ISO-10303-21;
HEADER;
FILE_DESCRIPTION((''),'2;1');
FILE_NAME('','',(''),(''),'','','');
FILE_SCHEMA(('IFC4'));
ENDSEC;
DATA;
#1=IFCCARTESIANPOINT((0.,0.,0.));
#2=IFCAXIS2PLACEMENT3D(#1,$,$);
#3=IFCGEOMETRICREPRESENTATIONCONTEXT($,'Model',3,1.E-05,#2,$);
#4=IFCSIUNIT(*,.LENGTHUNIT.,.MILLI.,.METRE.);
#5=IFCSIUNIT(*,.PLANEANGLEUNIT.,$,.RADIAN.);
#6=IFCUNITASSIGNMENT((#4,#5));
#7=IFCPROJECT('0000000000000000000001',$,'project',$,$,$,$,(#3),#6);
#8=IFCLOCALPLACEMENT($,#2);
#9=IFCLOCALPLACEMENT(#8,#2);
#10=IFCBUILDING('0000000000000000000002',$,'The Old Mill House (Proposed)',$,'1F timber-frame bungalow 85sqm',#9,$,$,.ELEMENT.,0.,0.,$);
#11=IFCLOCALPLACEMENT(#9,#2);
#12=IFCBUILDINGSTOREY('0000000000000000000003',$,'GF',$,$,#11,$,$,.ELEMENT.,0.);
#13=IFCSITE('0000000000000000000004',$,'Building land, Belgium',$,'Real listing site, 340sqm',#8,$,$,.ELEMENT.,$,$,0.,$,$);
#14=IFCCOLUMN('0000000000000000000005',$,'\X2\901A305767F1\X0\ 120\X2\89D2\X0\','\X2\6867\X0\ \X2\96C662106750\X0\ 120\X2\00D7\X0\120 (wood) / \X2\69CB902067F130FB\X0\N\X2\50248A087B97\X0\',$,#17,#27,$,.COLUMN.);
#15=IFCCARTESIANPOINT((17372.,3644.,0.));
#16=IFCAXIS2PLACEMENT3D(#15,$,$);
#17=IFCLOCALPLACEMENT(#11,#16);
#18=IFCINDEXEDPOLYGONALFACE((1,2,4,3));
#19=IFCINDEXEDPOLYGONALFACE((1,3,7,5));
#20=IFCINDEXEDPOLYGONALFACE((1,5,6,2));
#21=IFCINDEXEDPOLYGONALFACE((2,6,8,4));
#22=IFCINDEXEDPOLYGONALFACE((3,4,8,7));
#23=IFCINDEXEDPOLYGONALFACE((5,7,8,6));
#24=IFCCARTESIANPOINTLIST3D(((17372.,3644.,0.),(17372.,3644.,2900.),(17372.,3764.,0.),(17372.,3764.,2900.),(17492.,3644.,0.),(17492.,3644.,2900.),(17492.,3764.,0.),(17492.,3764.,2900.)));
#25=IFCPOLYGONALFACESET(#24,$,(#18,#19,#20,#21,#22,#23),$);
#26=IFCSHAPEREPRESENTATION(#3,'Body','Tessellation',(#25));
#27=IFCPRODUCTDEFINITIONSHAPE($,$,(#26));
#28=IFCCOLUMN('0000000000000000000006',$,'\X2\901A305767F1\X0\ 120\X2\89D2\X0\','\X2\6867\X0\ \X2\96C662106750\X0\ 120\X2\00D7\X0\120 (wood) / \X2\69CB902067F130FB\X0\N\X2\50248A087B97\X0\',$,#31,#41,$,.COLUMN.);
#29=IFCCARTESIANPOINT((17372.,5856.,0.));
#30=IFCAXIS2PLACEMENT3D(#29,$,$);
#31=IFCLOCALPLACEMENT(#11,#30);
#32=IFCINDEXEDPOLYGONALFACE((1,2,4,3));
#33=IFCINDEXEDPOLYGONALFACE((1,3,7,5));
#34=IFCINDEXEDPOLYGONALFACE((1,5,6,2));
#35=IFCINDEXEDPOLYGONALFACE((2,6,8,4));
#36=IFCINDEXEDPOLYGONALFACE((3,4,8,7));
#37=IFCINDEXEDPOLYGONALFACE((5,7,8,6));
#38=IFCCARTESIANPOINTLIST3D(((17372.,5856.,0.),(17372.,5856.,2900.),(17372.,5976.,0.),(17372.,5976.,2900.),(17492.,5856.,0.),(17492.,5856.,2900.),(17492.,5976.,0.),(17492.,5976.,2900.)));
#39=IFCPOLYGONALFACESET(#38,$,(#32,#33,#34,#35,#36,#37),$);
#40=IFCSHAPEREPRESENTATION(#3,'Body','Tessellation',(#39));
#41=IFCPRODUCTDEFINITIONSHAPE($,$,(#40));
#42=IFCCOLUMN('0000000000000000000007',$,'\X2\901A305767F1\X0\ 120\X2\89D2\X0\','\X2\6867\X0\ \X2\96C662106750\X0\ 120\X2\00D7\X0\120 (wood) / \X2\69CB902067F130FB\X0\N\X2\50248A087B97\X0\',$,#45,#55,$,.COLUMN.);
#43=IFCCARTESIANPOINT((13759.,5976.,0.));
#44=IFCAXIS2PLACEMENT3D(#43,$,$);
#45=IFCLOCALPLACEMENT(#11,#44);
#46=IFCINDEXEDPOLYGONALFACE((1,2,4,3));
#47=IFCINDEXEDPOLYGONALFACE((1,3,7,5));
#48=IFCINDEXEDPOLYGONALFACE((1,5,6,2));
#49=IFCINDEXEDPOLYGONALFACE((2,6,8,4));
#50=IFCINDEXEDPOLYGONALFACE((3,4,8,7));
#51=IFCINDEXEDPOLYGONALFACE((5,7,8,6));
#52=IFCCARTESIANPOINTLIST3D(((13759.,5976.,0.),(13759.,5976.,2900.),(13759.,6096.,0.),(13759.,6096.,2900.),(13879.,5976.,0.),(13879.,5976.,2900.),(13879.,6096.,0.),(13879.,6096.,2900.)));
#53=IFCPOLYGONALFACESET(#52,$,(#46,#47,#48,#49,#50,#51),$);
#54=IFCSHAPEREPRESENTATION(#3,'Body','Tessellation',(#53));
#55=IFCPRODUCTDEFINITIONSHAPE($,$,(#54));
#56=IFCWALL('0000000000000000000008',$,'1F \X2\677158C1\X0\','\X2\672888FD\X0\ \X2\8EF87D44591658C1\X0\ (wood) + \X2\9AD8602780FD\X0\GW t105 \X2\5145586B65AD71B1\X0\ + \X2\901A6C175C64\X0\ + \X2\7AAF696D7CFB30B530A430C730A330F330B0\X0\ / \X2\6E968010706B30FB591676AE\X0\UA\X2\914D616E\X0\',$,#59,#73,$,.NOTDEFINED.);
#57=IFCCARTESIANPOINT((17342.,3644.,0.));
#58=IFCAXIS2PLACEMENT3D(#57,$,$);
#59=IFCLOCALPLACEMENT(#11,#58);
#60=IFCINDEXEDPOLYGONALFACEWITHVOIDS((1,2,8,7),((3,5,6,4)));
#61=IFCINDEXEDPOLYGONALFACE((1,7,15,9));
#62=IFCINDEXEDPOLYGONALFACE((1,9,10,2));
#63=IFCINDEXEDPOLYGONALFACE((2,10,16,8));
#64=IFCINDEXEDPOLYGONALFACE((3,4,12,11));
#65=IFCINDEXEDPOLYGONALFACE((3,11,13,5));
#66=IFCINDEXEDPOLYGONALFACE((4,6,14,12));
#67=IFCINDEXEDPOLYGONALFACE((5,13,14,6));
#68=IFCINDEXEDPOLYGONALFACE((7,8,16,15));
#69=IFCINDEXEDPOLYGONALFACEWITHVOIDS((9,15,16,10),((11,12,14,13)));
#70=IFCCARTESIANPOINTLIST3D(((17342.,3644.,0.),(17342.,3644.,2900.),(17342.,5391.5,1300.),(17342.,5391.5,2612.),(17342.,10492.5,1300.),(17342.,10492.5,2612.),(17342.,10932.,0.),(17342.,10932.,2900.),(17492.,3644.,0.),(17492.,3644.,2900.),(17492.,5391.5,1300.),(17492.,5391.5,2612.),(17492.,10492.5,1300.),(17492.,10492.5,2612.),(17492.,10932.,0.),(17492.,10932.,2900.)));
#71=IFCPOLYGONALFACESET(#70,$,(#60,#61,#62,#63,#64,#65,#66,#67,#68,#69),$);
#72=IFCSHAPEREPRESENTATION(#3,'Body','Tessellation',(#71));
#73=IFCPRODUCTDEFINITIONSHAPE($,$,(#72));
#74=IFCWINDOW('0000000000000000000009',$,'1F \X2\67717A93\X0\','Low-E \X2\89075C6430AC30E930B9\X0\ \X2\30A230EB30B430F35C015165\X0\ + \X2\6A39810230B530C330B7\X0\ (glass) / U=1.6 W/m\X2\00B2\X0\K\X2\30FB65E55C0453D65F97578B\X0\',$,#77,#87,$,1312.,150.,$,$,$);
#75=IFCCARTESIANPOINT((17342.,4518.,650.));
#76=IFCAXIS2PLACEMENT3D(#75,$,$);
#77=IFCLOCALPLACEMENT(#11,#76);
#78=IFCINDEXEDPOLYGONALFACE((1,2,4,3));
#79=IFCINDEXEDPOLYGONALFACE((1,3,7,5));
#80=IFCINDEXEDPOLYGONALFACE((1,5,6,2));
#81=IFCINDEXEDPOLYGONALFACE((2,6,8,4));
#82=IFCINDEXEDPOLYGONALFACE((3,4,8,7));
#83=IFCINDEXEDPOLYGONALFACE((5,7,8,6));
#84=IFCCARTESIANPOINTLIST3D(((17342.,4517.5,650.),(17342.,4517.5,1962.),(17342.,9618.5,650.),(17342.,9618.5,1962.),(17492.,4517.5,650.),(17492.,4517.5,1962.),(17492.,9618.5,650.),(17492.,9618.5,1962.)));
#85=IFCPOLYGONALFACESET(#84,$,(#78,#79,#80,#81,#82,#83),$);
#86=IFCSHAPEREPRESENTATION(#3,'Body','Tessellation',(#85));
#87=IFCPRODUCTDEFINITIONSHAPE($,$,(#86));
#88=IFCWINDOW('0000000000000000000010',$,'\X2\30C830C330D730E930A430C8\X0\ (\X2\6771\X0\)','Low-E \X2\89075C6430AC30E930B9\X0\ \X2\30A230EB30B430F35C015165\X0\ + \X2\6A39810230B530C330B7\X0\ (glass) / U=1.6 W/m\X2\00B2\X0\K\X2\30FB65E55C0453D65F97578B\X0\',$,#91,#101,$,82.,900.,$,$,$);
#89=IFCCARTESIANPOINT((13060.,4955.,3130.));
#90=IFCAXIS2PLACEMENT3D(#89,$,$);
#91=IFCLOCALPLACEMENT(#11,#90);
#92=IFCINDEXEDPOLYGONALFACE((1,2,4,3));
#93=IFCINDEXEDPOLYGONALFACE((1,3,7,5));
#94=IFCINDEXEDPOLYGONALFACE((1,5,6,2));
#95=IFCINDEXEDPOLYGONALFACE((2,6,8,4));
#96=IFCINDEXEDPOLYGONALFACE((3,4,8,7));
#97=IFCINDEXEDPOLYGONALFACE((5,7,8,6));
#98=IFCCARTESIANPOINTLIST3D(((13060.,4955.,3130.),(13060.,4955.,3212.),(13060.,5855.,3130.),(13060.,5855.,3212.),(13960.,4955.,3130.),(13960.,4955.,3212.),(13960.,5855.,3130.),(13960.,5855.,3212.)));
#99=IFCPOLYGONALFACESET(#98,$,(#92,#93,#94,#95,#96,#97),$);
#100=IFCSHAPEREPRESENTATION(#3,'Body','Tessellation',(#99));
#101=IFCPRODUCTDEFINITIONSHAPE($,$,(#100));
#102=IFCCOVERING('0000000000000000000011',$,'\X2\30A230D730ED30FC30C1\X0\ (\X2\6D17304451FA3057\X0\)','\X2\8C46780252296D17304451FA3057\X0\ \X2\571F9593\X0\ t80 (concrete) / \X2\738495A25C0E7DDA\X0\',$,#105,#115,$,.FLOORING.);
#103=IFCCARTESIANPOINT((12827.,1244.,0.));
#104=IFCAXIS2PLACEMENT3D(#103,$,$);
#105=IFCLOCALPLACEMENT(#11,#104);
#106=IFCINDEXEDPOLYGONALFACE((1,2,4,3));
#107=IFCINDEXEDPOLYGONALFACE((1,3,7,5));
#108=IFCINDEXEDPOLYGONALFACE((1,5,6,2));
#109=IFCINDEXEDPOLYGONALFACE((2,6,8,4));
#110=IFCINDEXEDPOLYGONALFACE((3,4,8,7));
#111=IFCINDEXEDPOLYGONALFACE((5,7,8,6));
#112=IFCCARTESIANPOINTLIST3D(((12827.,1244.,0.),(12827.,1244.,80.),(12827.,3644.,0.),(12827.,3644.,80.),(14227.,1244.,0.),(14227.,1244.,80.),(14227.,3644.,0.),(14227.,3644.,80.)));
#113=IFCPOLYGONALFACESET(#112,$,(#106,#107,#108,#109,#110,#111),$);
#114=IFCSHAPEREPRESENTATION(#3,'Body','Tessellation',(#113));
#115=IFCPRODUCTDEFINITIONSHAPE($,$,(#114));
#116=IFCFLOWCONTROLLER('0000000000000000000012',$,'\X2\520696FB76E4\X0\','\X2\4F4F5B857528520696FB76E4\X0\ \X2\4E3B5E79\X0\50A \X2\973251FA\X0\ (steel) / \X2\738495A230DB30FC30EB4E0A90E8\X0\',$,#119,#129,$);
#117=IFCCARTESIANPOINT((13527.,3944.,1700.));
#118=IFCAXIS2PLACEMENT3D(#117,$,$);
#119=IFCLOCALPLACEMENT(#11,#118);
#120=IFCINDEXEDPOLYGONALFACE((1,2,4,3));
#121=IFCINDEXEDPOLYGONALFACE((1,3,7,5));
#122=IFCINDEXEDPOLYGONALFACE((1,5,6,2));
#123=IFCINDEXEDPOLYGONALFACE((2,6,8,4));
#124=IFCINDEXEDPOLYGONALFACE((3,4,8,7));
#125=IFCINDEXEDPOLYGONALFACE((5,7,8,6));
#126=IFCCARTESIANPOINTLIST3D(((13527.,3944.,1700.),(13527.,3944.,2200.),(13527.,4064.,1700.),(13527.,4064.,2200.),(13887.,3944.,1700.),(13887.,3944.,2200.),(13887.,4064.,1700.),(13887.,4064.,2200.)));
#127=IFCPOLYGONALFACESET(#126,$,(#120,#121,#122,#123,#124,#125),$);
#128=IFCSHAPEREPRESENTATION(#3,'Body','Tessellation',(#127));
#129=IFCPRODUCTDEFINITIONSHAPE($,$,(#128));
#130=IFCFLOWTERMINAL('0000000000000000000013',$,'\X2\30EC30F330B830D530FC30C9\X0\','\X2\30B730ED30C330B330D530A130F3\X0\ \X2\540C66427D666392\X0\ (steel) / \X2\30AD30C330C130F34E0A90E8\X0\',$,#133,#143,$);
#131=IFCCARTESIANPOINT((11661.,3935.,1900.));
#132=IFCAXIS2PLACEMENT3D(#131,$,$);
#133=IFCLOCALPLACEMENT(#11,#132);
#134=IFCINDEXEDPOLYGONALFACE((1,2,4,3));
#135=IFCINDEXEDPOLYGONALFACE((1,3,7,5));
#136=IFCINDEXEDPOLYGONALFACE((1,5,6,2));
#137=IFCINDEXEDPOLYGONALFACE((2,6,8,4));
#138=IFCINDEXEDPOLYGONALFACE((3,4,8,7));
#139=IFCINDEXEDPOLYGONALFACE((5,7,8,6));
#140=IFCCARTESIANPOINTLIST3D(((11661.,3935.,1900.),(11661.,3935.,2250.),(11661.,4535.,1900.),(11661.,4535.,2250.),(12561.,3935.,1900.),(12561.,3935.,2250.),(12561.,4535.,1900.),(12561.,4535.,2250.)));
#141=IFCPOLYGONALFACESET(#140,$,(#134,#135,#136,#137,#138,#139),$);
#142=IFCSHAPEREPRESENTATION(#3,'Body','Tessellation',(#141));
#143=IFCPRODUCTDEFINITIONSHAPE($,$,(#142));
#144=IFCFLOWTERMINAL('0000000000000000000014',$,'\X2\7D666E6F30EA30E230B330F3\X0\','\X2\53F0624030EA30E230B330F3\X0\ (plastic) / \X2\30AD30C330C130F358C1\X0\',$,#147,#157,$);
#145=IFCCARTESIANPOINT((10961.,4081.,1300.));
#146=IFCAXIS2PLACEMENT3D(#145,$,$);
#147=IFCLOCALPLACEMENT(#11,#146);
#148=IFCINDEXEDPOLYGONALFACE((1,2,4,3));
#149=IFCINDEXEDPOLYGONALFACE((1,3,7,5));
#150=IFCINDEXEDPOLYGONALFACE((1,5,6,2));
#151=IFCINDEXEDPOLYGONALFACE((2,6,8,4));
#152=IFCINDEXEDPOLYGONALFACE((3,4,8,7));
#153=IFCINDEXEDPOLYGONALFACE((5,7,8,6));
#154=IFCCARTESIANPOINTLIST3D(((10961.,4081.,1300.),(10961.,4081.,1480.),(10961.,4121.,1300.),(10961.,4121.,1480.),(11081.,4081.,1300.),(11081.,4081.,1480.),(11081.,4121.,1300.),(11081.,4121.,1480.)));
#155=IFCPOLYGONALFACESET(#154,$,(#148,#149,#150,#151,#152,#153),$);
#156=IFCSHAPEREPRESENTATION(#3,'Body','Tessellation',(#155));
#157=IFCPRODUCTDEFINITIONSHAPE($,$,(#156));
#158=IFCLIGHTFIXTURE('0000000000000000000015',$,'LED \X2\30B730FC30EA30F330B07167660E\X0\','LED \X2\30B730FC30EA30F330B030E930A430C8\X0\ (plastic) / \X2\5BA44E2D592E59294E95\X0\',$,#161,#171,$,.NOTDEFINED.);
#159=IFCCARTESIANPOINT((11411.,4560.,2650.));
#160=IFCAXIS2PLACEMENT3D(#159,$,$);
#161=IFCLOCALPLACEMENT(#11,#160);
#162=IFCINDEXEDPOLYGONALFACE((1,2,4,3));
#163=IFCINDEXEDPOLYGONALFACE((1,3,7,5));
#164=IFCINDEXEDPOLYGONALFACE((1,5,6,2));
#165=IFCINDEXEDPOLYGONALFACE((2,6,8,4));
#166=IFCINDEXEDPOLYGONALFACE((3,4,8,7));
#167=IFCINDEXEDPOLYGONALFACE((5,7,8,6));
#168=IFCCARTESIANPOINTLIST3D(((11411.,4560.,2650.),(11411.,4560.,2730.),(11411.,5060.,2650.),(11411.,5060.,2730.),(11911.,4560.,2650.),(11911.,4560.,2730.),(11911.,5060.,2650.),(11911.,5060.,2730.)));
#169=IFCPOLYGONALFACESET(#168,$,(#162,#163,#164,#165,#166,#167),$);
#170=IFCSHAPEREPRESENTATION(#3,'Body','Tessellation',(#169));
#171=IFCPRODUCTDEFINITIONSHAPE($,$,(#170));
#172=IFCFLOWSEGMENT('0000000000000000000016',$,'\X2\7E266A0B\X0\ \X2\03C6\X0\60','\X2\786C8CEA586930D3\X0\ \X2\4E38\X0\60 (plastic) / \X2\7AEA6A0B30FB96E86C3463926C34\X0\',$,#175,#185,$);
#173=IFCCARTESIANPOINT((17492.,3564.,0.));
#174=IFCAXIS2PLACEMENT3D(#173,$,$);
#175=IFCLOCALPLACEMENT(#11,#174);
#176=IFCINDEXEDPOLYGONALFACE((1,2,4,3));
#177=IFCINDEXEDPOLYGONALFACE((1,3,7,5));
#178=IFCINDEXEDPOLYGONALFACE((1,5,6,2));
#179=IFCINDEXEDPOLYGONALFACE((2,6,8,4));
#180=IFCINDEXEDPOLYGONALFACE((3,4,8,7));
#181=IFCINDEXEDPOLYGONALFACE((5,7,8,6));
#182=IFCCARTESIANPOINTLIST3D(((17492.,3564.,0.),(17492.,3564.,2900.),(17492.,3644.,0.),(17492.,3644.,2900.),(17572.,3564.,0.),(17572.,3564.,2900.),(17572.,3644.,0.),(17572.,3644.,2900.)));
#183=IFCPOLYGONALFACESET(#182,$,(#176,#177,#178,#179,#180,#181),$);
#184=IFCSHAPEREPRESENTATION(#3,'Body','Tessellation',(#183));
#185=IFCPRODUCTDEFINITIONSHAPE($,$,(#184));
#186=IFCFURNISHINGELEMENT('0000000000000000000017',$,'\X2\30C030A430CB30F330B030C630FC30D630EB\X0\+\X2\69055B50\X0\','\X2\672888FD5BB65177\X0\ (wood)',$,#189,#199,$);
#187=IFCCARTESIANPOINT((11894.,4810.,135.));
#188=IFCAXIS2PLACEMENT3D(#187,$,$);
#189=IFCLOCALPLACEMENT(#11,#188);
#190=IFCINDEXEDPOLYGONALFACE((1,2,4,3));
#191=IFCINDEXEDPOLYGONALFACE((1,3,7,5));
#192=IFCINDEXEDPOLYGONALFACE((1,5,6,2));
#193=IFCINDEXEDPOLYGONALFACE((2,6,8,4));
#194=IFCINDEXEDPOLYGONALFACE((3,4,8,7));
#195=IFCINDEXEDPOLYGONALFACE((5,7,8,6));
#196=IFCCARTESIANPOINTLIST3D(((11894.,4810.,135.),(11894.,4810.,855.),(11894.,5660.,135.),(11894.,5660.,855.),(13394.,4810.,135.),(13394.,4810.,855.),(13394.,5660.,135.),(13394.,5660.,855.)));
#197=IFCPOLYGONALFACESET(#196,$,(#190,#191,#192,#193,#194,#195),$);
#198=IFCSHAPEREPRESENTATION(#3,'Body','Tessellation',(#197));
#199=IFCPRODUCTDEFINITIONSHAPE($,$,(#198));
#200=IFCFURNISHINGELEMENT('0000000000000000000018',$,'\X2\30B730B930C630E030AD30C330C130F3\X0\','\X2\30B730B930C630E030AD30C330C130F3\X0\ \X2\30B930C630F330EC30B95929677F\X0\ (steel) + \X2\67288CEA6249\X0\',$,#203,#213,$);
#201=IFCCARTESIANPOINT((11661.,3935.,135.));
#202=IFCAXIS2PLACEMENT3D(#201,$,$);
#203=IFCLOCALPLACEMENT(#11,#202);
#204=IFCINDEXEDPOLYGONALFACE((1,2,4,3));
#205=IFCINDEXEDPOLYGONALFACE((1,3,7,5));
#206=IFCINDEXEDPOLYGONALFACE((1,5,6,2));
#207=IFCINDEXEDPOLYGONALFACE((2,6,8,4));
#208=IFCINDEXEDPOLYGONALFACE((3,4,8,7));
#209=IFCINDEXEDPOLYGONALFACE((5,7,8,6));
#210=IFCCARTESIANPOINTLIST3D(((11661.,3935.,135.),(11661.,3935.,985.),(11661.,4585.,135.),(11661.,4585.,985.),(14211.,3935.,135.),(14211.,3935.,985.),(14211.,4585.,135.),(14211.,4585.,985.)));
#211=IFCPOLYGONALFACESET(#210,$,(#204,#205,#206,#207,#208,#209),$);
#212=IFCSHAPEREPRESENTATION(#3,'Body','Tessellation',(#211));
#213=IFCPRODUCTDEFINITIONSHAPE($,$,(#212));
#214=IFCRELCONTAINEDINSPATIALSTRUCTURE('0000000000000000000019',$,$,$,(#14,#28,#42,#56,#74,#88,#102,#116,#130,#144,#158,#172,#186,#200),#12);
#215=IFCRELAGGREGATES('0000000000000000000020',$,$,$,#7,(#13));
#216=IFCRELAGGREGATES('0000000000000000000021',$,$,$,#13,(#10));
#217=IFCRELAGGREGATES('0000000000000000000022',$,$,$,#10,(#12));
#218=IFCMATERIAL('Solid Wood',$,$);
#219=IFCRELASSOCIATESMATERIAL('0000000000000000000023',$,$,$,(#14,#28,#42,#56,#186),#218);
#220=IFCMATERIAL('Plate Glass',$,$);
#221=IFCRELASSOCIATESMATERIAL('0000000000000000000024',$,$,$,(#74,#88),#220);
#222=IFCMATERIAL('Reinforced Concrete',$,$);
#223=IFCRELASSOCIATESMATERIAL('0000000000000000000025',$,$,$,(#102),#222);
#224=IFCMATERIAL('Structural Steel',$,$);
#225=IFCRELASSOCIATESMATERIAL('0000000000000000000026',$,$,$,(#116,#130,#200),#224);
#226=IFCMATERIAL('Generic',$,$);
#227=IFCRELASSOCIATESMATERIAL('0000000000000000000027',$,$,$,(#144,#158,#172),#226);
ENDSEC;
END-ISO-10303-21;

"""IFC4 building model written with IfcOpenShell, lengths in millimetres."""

from ifc_helpers import new_model, si_unit, frame, frame_2d, origin, place, context, project, spatial, rectangle, extrude, material, element, fill, save


model = new_model("IFC4")

# Units and contexts
model_context = context("Model", 3, precision=1e-05, world=origin())
ifc_project = project(units=[si_unit("LENGTHUNIT", "METRE", prefix="MILLI"), si_unit("PLANEANGLEUNIT", "RADIAN")], contexts=[model_context])

# Site, building, storey
site_placement = place(None, origin())
site = spatial("IfcSite", under=ifc_project, at=site_placement, Name="Building land, Belgium", ObjectType="Real listing site, 340sqm", CompositionType="ELEMENT", RefElevation=0.0)
building_placement = place(site_placement, origin())
building = spatial("IfcBuilding", under=site, at=building_placement, Name="The Old Mill House (Proposed)", ObjectType="1F timber-frame bungalow 85sqm", CompositionType="ELEMENT", ElevationOfRefHeight=0.0, ElevationOfTerrain=0.0)
storey_placement = place(building_placement, origin())
storey = spatial("IfcBuildingStorey", under=building, at=storey_placement, Name="GF", CompositionType="ELEMENT", Elevation=0.0)

# Columns
ifc_material_1 = material(Name="Solid Wood")
column_1_placement = place(storey_placement, frame((17372.0, 3644.0, 0.0)))
element("IfcColumn", 1, at=column_1_placement, inside=storey, material=ifc_material_1, Name="通し柱 120角", Description="桧 集成材 120×120 (wood) / 構造柱・N値計算", PredefinedType="COLUMN", context=model_context, shape_type="SweptSolid", body=[
    extrude(rectangle(XDim=120.0, YDim=120.0, at=frame_2d((60.0, 60.0))), frame((17372.0, 3644.0, 0.0)), (0.0, 0.0, 1.0), 2900.0),
])
column_2_placement = place(storey_placement, frame((17372.0, 5856.0, 0.0)))
element("IfcColumn", 2, at=column_2_placement, inside=storey, material=ifc_material_1, Name="通し柱 120角", Description="桧 集成材 120×120 (wood) / 構造柱・N値計算", PredefinedType="COLUMN", context=model_context, shape_type="SweptSolid", body=[
    extrude(rectangle(XDim=120.0, YDim=120.0, at=frame_2d((60.0, 60.0))), frame((17372.0, 5856.0, 0.0)), (0.0, 0.0, 1.0), 2900.0),
])
column_3_placement = place(storey_placement, frame((13759.0, 5976.0, 0.0)))
element("IfcColumn", 3, at=column_3_placement, inside=storey, material=ifc_material_1, Name="通し柱 120角", Description="桧 集成材 120×120 (wood) / 構造柱・N値計算", PredefinedType="COLUMN", context=model_context, shape_type="SweptSolid", body=[
    extrude(rectangle(XDim=120.0, YDim=120.0, at=frame_2d((60.0, 60.0))), frame((13759.0, 5976.0, 0.0)), (0.0, 0.0, 1.0), 2900.0),
])

# Wall, opening, window
wall_1_placement = place(storey_placement, frame((17342.0, 3644.0, 0.0)))
wall_1 = element("IfcWall", 4, at=wall_1_placement, inside=storey, material=ifc_material_1, Name="1F 東壁", Description="木製 軸組外壁 (wood) + 高性能GW t105 充填断熱 + 通気層 + 窯業系サイディング / 準耐火・外皮UA配慮", PredefinedType="NOTDEFINED", context=model_context, shape_type="SweptSolid", body=[
    extrude(rectangle(XDim=150.0, YDim=7288.0, at=frame_2d((75.0, 3644.0))), frame((17342.0, 3644.0, 0.0)), (0.0, 0.0, 1.0), 2900.0),
])
opening_1_placement = place(storey_placement, frame((17342.0, 4518.0, 650.0)))
opening_1 = element("IfcOpeningElement", 5, at=opening_1_placement, cuts=wall_1, PredefinedType="NOTDEFINED", context=model_context, shape_type="SweptSolid", body=[
    extrude(rectangle(XDim=150.0, YDim=5101.0, at=frame_2d((75.0, 2550.0))), frame((17342.0, 4518.0, 650.0)), (0.0, 0.0, 1.0), 1312.0),
])
ifc_material_2 = material(Name="Plate Glass")
window_1_placement = place(storey_placement, frame((17342.0, 4518.0, 650.0)))
window_1 = element("IfcWindow", 6, at=window_1_placement, inside=storey, material=ifc_material_2, Name="1F 東窓", Description="Low-E 複層ガラス アルゴン封入 + 樹脂サッシ (glass) / U=1.6 W/m²K・日射取得型", OverallHeight=1312.0, OverallWidth=150.0, context=model_context, shape_type="SweptSolid", body=[
    extrude(rectangle(XDim=150.0, YDim=5101.0, at=frame_2d((75.0, 2550.0))), frame((17342.0, 4518.0, 650.0)), (0.0, 0.0, 1.0), 1312.0),
])
fill(opening_1, window_1)

# Window
window_2_placement = place(storey_placement, frame((13060.0, 4955.0, 3130.0)))
element("IfcWindow", 7, at=window_2_placement, inside=storey, material=ifc_material_2, Name="トップライト (東)", Description="Low-E 複層ガラス アルゴン封入 + 樹脂サッシ (glass) / U=1.6 W/m²K・日射取得型", OverallHeight=82.0, OverallWidth=900.0, context=model_context, shape_type="SweptSolid", body=[
    extrude(rectangle(XDim=900.0, YDim=900.0, at=frame_2d((450.0, 450.0))), frame((13060.0, 4955.0, 3130.0)), (0.0, 0.0, 1.0), 82.0),
])

# Shared definitions
ifc_material_3 = material(Name="Structural Steel")

# Covering
ifc_material_4 = material(Name="Reinforced Concrete")
covering_placement = place(storey_placement, frame((12827.0, 1244.0, 0.0)))
element("IfcCovering", 8, at=covering_placement, inside=storey, material=ifc_material_4, Name="アプローチ (洗い出し)", Description="豆砂利洗い出し 土間 t80 (concrete) / 玄関導線", PredefinedType="FLOORING", context=model_context, shape_type="SweptSolid", body=[
    extrude(rectangle(XDim=1400.0, YDim=2400.0, at=frame_2d((700.0, 1200.0))), frame((12827.0, 1244.0, 0.0)), (0.0, 0.0, 1.0), 80.0),
])

# Flow controller
flow_controller_placement = place(storey_placement, frame((13527.0, 3944.0, 1700.0)))
element("IfcFlowController", 9, at=flow_controller_placement, inside=storey, material=ifc_material_3, Name="分電盤", Description="住宅用分電盤 主幹50A 露出 (steel) / 玄関ホール上部", context=model_context, shape_type="SweptSolid", body=[
    extrude(rectangle(XDim=360.0, YDim=120.0, at=frame_2d((180.0, 60.0))), frame((13527.0, 3944.0, 1700.0)), (0.0, 0.0, 1.0), 500.0),
])

# Flow terminals
flow_terminal_1_placement = place(storey_placement, frame((11661.0, 3935.0, 1900.0)))
element("IfcFlowTerminal", 10, at=flow_terminal_1_placement, inside=storey, material=ifc_material_3, Name="レンジフード", Description="シロッコファン 同時給排 (steel) / キッチン上部", context=model_context, shape_type="SweptSolid", body=[
    extrude(rectangle(XDim=900.0, YDim=600.0, at=frame_2d((450.0, 300.0))), frame((11661.0, 3935.0, 1900.0)), (0.0, 0.0, 1.0), 350.0),
])
ifc_material_5 = material(Name="Generic")
flow_terminal_2_placement = place(storey_placement, frame((10961.0, 4081.0, 1300.0)))
element("IfcFlowTerminal", 11, at=flow_terminal_2_placement, inside=storey, material=ifc_material_5, Name="給湯リモコン", Description="台所リモコン (plastic) / キッチン壁", context=model_context, shape_type="SweptSolid", body=[
    extrude(rectangle(XDim=120.0, YDim=40.0, at=frame_2d((60.0, 20.0))), frame((10961.0, 4081.0, 1300.0)), (0.0, 0.0, 1.0), 180.0),
])

# Light fixture
light_fixture_placement = place(storey_placement, frame((11411.0, 4560.0, 2650.0)))
element("IfcLightFixture", 12, at=light_fixture_placement, inside=storey, material=ifc_material_5, Name="LED シーリング照明", Description="LED シーリングライト (plastic) / 室中央天井", PredefinedType="NOTDEFINED", context=model_context, shape_type="SweptSolid", body=[
    extrude(rectangle(XDim=500.0, YDim=500.0, at=frame_2d((250.0, 250.0))), frame((11411.0, 4560.0, 2650.0)), (0.0, 0.0, 1.0), 80.0),
])

# Flow segment
flow_segment_placement = place(storey_placement, frame((17492.0, 3564.0, 0.0)))
element("IfcFlowSegment", 13, at=flow_segment_placement, inside=storey, material=ifc_material_5, Name="縦樋 φ60", Description="硬質塩ビ 丸60 (plastic) / 竪樋・雨水排水", context=model_context, shape_type="SweptSolid", body=[
    extrude(rectangle(XDim=80.0, YDim=80.0, at=frame_2d((40.0, 40.0))), frame((17492.0, 3564.0, 0.0)), (0.0, 0.0, 1.0), 2900.0),
])

# Furnishing elements
furnishing_1_placement = place(storey_placement, frame((11894.0, 4810.0, 135.0)))
element("IfcFurnishingElement", 14, at=furnishing_1_placement, inside=storey, material=ifc_material_1, Name="ダイニングテーブル+椅子", Description="木製家具 (wood)", context=model_context, shape_type="SweptSolid", body=[
    extrude(rectangle(XDim=1500.0, YDim=850.0, at=frame_2d((750.0, 425.0))), frame((11894.0, 4810.0, 135.0)), (0.0, 0.0, 1.0), 720.0),
])
furnishing_2_placement = place(storey_placement, frame((11661.0, 3935.0, 135.0)))
element("IfcFurnishingElement", 15, at=furnishing_2_placement, inside=storey, material=ifc_material_3, Name="システムキッチン", Description="システムキッチン ステンレス天板 (steel) + 木質扉", context=model_context, shape_type="SweptSolid", body=[
    extrude(rectangle(XDim=2550.0, YDim=650.0, at=frame_2d((1275.0, 325.0))), frame((11661.0, 3935.0, 135.0)), (0.0, 0.0, 1.0), 850.0),
])

save(model, "model.ifc")
